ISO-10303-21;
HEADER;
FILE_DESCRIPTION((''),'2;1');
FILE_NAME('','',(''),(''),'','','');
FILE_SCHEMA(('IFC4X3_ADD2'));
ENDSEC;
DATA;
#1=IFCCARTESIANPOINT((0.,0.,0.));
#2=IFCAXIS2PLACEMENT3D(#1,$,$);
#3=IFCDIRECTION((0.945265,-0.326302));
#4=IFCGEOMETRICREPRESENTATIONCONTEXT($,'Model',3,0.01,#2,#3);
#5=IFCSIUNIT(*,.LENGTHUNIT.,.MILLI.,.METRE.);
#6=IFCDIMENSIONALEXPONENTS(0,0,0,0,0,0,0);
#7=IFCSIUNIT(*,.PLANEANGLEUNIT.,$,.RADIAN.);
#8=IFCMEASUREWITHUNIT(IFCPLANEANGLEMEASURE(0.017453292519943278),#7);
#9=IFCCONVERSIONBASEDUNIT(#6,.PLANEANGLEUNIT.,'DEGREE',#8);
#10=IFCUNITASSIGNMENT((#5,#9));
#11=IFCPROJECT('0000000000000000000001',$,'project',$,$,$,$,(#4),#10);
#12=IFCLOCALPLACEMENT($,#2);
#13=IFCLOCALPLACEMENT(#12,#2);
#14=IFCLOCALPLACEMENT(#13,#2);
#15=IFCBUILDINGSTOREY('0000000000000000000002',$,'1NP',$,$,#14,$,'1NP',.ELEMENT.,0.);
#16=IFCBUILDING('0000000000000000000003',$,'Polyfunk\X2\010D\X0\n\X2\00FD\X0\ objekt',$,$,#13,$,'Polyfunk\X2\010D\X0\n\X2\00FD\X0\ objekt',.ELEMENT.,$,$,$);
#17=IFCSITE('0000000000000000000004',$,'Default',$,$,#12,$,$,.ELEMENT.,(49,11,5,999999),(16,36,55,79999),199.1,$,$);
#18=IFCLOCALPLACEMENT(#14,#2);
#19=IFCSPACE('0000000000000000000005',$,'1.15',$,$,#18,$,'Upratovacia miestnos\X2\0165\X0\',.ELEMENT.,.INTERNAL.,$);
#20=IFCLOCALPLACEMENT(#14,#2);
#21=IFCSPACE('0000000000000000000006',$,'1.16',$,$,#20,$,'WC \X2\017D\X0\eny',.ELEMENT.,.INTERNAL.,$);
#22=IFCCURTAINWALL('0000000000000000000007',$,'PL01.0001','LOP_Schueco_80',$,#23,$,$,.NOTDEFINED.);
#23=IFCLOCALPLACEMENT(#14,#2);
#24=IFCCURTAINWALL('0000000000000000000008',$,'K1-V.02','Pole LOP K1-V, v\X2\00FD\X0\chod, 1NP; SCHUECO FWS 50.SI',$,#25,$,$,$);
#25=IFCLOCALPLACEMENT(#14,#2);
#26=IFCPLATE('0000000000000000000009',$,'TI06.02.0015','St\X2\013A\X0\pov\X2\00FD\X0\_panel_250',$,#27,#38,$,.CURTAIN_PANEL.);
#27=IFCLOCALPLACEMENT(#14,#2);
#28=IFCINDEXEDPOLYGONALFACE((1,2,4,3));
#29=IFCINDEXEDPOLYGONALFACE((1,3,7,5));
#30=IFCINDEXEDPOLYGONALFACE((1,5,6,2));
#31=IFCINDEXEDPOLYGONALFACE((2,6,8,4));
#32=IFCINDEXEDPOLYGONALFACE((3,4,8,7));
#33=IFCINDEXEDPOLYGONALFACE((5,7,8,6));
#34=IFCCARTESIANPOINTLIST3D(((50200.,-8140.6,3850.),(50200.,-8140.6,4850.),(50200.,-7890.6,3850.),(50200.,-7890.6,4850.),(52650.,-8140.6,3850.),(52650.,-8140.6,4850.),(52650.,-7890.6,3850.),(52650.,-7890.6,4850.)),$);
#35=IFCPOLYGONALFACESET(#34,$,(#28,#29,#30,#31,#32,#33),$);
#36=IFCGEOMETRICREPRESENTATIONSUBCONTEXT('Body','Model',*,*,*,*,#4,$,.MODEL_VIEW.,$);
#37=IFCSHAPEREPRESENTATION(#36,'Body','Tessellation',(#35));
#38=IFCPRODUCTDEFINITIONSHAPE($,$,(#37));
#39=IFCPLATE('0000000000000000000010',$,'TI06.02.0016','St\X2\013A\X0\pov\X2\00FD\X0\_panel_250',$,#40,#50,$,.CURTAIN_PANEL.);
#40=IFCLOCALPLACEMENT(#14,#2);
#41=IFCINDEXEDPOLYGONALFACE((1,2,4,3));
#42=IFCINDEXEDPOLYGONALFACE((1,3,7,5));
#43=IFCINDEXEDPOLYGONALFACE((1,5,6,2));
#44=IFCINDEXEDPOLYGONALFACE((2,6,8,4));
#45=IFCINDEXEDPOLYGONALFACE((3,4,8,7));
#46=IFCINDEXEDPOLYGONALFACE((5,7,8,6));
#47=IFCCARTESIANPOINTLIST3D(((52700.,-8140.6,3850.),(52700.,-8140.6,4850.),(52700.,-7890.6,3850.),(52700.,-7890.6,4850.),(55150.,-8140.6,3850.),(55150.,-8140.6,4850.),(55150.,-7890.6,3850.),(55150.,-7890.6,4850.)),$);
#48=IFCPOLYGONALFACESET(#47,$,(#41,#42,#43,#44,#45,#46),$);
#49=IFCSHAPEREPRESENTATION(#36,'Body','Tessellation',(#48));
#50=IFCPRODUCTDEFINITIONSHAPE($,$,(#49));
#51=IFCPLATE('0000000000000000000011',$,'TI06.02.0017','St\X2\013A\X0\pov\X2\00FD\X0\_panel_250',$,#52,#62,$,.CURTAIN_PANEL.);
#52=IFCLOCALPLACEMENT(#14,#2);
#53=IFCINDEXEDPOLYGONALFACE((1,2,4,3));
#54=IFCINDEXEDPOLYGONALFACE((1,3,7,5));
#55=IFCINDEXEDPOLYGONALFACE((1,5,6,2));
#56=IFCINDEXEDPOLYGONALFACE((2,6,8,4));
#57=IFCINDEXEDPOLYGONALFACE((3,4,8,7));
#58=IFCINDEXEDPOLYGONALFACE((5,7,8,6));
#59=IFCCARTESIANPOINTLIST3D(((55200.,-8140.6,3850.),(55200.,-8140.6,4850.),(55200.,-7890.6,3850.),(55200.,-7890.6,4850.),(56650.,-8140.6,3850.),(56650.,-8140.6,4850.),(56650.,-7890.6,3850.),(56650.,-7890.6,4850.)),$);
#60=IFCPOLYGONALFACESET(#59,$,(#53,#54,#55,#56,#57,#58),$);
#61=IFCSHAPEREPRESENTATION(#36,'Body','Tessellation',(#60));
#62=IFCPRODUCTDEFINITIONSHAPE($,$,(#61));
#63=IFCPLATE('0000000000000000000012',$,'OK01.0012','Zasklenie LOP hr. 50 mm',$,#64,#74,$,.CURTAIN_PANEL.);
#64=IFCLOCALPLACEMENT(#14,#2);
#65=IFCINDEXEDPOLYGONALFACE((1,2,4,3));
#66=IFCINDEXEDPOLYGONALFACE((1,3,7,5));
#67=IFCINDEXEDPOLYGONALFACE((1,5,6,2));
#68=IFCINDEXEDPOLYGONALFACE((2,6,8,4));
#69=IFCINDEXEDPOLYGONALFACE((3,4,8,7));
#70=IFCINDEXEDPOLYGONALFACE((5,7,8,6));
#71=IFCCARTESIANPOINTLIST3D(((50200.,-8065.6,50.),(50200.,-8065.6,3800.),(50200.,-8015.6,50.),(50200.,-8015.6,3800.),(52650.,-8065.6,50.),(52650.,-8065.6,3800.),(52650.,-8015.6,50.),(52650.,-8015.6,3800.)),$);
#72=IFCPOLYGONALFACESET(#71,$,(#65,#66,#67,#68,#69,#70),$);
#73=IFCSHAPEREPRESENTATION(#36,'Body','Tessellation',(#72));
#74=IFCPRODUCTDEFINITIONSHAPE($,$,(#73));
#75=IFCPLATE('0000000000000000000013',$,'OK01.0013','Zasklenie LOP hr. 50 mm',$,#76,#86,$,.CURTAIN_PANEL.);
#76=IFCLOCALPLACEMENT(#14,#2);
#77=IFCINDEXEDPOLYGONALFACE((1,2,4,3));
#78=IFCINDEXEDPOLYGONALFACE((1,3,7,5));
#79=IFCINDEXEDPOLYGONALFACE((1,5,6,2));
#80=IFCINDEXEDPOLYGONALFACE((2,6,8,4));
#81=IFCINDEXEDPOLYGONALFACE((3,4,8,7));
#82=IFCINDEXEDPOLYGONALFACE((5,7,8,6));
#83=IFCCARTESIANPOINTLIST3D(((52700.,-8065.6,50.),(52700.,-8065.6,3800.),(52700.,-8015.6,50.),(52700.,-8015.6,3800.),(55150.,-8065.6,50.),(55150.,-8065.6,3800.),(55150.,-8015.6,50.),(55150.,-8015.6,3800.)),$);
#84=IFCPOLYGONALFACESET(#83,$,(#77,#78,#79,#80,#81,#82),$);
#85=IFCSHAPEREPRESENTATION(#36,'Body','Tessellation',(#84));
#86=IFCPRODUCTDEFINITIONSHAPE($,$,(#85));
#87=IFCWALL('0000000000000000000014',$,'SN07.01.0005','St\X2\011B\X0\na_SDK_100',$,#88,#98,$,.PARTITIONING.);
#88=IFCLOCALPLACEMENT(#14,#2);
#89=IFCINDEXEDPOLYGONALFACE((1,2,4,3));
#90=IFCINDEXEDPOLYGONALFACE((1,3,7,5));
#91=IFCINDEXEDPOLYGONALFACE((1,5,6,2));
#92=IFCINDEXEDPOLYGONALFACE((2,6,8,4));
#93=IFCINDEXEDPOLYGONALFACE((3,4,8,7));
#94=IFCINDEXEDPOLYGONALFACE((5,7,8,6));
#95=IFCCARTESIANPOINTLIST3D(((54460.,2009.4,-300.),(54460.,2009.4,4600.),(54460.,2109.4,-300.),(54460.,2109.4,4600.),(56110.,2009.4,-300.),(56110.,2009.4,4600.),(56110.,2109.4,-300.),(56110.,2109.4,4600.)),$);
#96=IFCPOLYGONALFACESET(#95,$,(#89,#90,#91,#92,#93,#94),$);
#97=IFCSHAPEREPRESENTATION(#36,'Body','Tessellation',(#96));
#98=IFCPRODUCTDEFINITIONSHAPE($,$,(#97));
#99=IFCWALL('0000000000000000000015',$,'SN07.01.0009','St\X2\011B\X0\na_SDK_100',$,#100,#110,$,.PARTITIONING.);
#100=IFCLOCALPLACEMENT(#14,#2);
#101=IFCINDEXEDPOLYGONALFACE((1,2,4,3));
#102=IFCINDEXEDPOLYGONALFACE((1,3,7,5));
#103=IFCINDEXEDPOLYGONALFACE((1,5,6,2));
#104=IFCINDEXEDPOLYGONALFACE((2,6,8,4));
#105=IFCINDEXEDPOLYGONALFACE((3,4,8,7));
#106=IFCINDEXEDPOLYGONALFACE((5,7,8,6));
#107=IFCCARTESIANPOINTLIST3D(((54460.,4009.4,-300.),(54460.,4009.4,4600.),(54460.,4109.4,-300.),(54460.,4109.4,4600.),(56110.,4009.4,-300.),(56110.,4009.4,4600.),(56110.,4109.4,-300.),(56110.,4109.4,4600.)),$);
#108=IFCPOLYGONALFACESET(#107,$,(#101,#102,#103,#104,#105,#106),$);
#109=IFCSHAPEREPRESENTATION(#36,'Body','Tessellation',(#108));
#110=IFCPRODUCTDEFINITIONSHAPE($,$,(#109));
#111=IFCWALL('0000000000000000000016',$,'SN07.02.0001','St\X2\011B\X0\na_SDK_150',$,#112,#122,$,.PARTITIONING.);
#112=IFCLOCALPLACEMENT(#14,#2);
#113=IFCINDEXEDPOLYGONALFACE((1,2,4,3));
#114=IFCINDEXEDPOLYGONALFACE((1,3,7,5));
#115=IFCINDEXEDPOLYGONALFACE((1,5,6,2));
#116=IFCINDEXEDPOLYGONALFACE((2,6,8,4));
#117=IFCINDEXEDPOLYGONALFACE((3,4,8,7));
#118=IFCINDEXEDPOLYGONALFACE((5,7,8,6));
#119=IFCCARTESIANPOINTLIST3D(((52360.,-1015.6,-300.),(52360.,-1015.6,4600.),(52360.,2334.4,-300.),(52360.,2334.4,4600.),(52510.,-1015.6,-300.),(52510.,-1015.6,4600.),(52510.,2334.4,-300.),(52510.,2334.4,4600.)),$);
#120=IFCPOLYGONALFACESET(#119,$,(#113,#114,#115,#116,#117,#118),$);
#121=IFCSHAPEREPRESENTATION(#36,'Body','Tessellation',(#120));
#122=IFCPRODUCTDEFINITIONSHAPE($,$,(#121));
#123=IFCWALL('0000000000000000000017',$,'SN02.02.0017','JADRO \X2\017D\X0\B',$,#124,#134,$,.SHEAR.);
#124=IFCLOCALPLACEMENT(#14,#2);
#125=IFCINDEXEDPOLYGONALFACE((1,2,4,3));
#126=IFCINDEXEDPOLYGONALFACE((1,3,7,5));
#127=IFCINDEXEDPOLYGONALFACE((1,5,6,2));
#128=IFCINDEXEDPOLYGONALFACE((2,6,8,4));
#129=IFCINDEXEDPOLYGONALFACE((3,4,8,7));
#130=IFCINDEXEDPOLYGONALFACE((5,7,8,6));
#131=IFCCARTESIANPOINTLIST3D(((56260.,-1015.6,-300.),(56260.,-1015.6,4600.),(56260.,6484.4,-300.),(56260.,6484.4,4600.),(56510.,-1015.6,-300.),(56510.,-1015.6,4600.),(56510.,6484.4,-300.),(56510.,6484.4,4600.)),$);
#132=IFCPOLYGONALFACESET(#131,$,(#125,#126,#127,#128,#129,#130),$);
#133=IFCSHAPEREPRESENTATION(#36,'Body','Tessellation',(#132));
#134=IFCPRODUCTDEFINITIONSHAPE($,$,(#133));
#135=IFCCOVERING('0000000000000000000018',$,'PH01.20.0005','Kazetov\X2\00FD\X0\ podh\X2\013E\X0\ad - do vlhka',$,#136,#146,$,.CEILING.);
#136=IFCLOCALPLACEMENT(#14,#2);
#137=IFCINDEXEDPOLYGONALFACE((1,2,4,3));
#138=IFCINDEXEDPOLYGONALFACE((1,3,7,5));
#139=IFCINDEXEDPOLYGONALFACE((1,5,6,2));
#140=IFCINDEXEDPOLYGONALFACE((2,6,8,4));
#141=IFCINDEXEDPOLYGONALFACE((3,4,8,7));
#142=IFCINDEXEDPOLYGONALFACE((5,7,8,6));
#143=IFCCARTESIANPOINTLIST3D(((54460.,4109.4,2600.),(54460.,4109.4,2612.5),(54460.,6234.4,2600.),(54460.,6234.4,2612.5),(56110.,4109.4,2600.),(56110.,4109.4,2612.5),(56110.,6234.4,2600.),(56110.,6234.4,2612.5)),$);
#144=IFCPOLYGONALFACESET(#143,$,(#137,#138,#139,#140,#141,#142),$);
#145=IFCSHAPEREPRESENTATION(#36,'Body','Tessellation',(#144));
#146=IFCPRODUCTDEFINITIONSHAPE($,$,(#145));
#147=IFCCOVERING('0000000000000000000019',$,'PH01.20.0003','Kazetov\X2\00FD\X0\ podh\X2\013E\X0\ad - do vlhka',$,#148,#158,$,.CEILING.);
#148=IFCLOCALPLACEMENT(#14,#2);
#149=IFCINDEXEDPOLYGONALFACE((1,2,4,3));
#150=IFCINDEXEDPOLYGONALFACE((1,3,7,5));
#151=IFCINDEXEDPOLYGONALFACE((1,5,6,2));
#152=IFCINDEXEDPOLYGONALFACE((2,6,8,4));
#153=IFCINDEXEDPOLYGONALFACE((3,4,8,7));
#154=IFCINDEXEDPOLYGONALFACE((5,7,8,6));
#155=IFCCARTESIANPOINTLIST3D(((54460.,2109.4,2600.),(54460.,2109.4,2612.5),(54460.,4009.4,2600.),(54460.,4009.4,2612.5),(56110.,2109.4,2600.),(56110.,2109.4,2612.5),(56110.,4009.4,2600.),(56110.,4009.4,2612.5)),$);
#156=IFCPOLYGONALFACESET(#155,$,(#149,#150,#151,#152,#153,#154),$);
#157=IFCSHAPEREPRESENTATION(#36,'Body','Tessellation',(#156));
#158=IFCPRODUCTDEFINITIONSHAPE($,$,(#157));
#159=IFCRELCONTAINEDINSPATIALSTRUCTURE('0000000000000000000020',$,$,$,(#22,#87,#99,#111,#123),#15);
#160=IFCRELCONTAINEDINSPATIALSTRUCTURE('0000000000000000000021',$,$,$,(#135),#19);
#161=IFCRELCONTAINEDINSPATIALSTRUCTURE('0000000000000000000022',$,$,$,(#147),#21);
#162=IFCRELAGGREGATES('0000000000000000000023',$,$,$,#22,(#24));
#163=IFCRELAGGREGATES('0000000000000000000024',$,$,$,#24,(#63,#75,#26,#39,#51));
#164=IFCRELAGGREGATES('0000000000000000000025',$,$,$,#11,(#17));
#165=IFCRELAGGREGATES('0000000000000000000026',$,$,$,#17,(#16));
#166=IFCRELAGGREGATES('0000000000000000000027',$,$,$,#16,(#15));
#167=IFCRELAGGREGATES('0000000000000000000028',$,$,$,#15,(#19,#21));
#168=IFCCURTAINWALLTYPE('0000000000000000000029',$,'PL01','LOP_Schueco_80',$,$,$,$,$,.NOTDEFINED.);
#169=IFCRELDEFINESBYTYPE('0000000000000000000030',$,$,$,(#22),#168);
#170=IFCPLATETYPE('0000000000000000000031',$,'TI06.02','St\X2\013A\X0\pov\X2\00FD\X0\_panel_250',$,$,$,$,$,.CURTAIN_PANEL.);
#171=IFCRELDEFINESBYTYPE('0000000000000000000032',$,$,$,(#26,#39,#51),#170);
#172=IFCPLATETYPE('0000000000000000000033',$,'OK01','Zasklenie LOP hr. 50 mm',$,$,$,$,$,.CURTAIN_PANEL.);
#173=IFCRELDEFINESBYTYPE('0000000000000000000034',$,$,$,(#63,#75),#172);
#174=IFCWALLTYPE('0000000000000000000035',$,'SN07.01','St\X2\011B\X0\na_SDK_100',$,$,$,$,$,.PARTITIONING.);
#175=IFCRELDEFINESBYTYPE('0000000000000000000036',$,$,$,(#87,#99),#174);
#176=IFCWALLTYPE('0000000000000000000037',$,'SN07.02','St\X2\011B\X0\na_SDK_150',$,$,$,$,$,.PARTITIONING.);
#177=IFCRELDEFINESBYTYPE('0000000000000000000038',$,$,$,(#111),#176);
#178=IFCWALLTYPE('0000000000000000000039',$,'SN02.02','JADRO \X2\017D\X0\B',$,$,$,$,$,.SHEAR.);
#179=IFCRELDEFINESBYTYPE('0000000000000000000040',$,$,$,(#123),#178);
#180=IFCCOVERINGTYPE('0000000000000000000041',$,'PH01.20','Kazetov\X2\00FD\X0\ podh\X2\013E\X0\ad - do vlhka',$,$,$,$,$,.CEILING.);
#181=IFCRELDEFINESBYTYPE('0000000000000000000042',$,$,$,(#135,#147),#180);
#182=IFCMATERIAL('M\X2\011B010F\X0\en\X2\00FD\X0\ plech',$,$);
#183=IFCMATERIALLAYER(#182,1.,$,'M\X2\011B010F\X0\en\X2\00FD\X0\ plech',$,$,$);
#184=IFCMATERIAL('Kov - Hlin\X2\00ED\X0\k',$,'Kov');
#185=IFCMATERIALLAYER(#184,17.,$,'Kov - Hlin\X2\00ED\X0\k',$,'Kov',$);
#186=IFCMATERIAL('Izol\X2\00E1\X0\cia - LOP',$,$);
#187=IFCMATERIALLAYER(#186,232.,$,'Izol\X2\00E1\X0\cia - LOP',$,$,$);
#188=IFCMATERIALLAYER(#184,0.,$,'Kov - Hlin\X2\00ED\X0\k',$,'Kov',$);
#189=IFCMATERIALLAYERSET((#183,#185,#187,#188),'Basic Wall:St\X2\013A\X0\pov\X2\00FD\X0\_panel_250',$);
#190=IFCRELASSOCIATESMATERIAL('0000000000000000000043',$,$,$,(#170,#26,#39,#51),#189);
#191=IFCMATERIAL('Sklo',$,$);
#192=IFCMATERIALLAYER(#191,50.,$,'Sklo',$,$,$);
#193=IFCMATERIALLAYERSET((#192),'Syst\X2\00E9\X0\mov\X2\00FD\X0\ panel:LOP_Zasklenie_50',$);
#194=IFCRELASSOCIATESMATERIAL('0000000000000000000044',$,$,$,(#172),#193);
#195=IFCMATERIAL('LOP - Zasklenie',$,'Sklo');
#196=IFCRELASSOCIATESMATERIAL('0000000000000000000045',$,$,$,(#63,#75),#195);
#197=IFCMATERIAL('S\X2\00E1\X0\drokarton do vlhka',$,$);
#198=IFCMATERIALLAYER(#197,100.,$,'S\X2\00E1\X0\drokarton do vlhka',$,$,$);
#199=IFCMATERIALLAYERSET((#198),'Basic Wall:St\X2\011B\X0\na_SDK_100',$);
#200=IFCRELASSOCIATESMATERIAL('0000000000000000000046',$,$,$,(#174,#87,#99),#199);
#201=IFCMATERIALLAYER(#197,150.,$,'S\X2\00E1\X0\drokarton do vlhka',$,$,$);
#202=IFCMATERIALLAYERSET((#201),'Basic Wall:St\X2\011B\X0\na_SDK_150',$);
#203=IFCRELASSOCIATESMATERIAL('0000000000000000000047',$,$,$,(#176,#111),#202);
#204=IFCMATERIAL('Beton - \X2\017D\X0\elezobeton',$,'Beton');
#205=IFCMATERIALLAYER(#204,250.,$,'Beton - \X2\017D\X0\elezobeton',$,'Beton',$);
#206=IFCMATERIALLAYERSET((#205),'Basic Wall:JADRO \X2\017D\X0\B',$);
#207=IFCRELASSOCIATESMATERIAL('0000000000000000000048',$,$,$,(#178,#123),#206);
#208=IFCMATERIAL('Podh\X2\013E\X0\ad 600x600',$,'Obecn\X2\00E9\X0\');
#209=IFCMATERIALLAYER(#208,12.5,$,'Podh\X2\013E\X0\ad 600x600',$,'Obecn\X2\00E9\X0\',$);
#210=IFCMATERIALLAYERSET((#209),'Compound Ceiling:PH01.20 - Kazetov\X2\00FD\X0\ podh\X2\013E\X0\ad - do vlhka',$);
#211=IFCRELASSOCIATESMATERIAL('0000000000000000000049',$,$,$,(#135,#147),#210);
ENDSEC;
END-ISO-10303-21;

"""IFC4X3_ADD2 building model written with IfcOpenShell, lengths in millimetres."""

from ifc_helpers import new_model, entity, si_unit, converted_unit, direction, frame, frame_2d, origin, origin_2d_with_axis, place, context, subcontext, project, spatial, polyline, rectangle, extrude, clip, bounded_halfspace, source, transform, mapped, material, layer, layer_set, layer_usage, type_object, type_shapes, element, aggregate, save


model = new_model("IFC4X3_ADD2")

# Units and contexts
model_context = context("Model", 3, precision=0.01, world=origin(), true_north=direction((0.945265, -0.326302)))
body_context = subcontext(model_context, "Body", "Model", "MODEL_VIEW")
ifc_project = project(units=[si_unit("LENGTHUNIT", "METRE", prefix="MILLI"), converted_unit("PLANEANGLEUNIT", "DEGREE", entity("IfcPlaneAngleMeasure", 0.017453292519943278), si_unit("PLANEANGLEUNIT", "RADIAN"), dimensions=[0, 0, 0, 0, 0, 0, 0])], contexts=[model_context])

# Site, building, storey
site_placement = place(None, origin())
site = spatial("IfcSite", under=ifc_project, at=site_placement, Name="Default", CompositionType="ELEMENT", RefLatitude=(49, 11, 5, 999999), RefLongitude=(16, 36, 55, 79999), RefElevation=199.1)
building_placement = place(site_placement, origin())
building = spatial("IfcBuilding", under=site, at=building_placement, Name="Polyfunkčný objekt", LongName="Polyfunkčný objekt", CompositionType="ELEMENT")
storey_placement = place(building_placement, origin())
storey = spatial("IfcBuildingStorey", under=building, at=storey_placement, Name="1NP", LongName="1NP", CompositionType="ELEMENT", Elevation=0.0)

# Curtain walls, plates
curtain_wall_type = type_object("IfcCurtainWallType", Name="PL01", Description="LOP_Schueco_80", PredefinedType="NOTDEFINED")
curtain_wall_1_placement = place(storey_placement, origin())
curtain_wall_1 = element("IfcCurtainWall", 1, at=curtain_wall_1_placement, inside=storey, type_object=curtain_wall_type, Name="PL01.0001", Description="LOP_Schueco_80", PredefinedType="NOTDEFINED")
curtain_wall_2 = element("IfcCurtainWall", 2, Name="K1-V.02", Description="Pole LOP K1-V, východ, 1NP; SCHUECO FWS 50.SI")
aggregate(curtain_wall_1, [curtain_wall_2])
ifc_material_1 = material(Name="Měďený plech")
ifc_layer_1 = layer(ifc_material_1, 1.0, Name="Měďený plech")
ifc_material_2 = material(Name="Kov - Hliník", Category="Kov")
ifc_layer_2 = layer(ifc_material_2, 17.0, Name="Kov - Hliník", Category="Kov")
ifc_material_3 = material(Name="Izolácia - LOP")
ifc_layer_3 = layer(ifc_material_3, 232.0, Name="Izolácia - LOP")
ifc_layer_4 = layer(ifc_material_2, 0.0, Name="Kov - Hliník", Category="Kov")
ifc_layer_set_1 = layer_set([ifc_layer_1, ifc_layer_2, ifc_layer_3, ifc_layer_4], Name="Basic Wall:Stĺpový_panel_250")
ifc_layer_usage_1 = layer_usage(ifc_layer_set_1, "AXIS2", "POSITIVE", -125.0)
plate_type_1 = type_object("IfcPlateType", Name="TI06.02", Description="Stĺpový_panel_250", PredefinedType="CURTAIN_PANEL", material=ifc_layer_set_1)
plate_1_placement = place(storey_placement, frame((50200.0, -8015.6, 3850.0)))
plate_1 = element("IfcPlate", 3, at=plate_1_placement, type_object=plate_type_1, material=ifc_layer_usage_1, Name="TI06.02.0015", Description="Stĺpový_panel_250", PredefinedType="CURTAIN_PANEL", context=body_context, shape_type="SweptSolid", body=[
    extrude(rectangle(XDim=250.0, YDim=2450.0, at=origin_2d_with_axis()), frame((1225.0, 0.0, 0.0), z_axis=(0.0, 0.0, 1.0), x_axis=(0.0, 1.0, 0.0)), (0.0, 0.0, 1.0), 1000.0),
])
ifc_layer_usage_2 = layer_usage(ifc_layer_set_1, "AXIS2", "POSITIVE", -125.0)
plate_2_placement = place(storey_placement, frame((52700.0, -8015.6, 3850.0)))
plate_2 = element("IfcPlate", 4, at=plate_2_placement, type_object=plate_type_1, material=ifc_layer_usage_2, Name="TI06.02.0016", Description="Stĺpový_panel_250", PredefinedType="CURTAIN_PANEL", context=body_context, shape_type="SweptSolid", body=[
    extrude(rectangle(XDim=250.0, YDim=2450.0, at=frame_2d((0.0, 0.0), x_axis=(1.0, 0.0))), frame((1225.0, 0.0, 0.0), z_axis=(0.0, 0.0, 1.0), x_axis=(0.0, 1.0, 0.0)), (0.0, 0.0, 1.0), 1000.0),
])
ifc_layer_usage_3 = layer_usage(ifc_layer_set_1, "AXIS2", "POSITIVE", -125.0)
plate_3_placement = place(storey_placement, frame((55200.0, -8015.6, 3850.0)))
plate_3 = element("IfcPlate", 5, at=plate_3_placement, type_object=plate_type_1, material=ifc_layer_usage_3, Name="TI06.02.0017", Description="Stĺpový_panel_250", PredefinedType="CURTAIN_PANEL", context=body_context, shape_type="SweptSolid", body=[
    extrude(rectangle(XDim=250.0, YDim=1450.0, at=frame_2d((0.0, 0.0), x_axis=(1.0, 0.0))), frame((725.0, 0.0, 0.0), z_axis=(0.0, 0.0, 1.0), x_axis=(0.0, 1.0, 0.0)), (0.0, 0.0, 1.0), 1000.0),
])
ifc_material_4 = material(Name="LOP - Zasklenie", Category="Sklo")
ifc_material_5 = material(Name="Sklo")
ifc_layer_5 = layer(ifc_material_5, 50.0, Name="Sklo")
ifc_layer_set_2 = layer_set([ifc_layer_5], Name="Systémový panel:LOP_Zasklenie_50")
plate_type_2 = type_object("IfcPlateType", Name="OK01", Description="Zasklenie LOP hr. 50 mm", PredefinedType="CURTAIN_PANEL", material=ifc_layer_set_2)
shared_shape_1 = source(origin(), body_context, "Body", "SweptSolid", [
    extrude(rectangle(XDim=3750.0, YDim=2450.0, at=frame_2d((-331.2, 0.0), x_axis=(1.0, 0.0))), frame((0.0, -50.0, 2206.2), z_axis=(0.0, 1.0, 0.0), x_axis=(0.0, 0.0, 1.0)), (0.0, 0.0, 1.0), 50.0),
])
type_shapes(plate_type_2, [shared_shape_1])
plate_4_placement = place(curtain_wall_1_placement, frame((51425.0, -8015.6, 50.0)))
plate_4 = element("IfcPlate", 6, at=plate_4_placement, type_object=plate_type_2, material=ifc_material_4, Name="OK01.0012", Description="Zasklenie LOP hr. 50 mm", PredefinedType="CURTAIN_PANEL", context=body_context, shape_type="MappedRepresentation", body=[
    mapped(shared_shape_1, transform((0.0, 0.0, 0.0), scale=1.0)),
])
plate_5_placement = place(curtain_wall_1_placement, frame((53925.0, -8015.6, 50.0)))
plate_5 = element("IfcPlate", 7, at=plate_5_placement, type_object=plate_type_2, material=ifc_material_4, Name="OK01.0013", Description="Zasklenie LOP hr. 50 mm", PredefinedType="CURTAIN_PANEL", context=body_context, shape_type="MappedRepresentation", body=[
    mapped(shared_shape_1, transform((0.0, 0.0, 0.0), scale=1.0)),
])
aggregate(curtain_wall_2, [plate_4, plate_5, plate_1, plate_2, plate_3])

# Walls
ifc_material_6 = material(Name="Sádrokarton do vlhka")
ifc_layer_6 = layer(ifc_material_6, 100.0, Name="Sádrokarton do vlhka")
ifc_layer_set_3 = layer_set([ifc_layer_6], Name="Basic Wall:Stěna_SDK_100")
wall_type_1 = type_object("IfcWallType", Name="SN07.01", Description="Stěna_SDK_100", PredefinedType="PARTITIONING", material=ifc_layer_set_3)
wall_1_placement = place(storey_placement, frame((54460.0, 2059.4, -300.0)))
element("IfcWall", 8, at=wall_1_placement, inside=storey, type_object=wall_type_1, material=ifc_layer_set_3, Name="SN07.01.0005", Description="Stěna_SDK_100", PredefinedType="PARTITIONING", context=body_context, shape_type="Clipping", body=[
    clip(clip(extrude(rectangle(XDim=1650.0, YDim=100.0, at=frame_2d((825.0, 0.0), x_axis=(-1.0, 0.0))), origin(), (0.0, 0.0, 1.0), 4900.0), bounded_halfspace(frame((0.0, -50.0, 4900.0), z_axis=(0.0, 0.0, -1.0), x_axis=(1.0, 0.0, 0.0)), True, frame((0.0, -50.0, 4900.0)), polyline([(0.0, 0.0), (1650.0, 0.0), (1650.0, 100.0), (0.0, 100.0), (0.0, 0.0)]))), bounded_halfspace(frame((1650.0, -50.0, 0.0), z_axis=(0.0, 0.0, 1.0), x_axis=(0.0, 1.0, 0.0)), True, frame((1650.0, -50.0, 0.0)), polyline([(0.0, 0.0), (0.0, 100.0), (-1650.0, 100.0), (-1650.0, 0.0), (0.0, 0.0)]))),
])
wall_2_placement = place(storey_placement, frame((54460.0, 4059.4, -300.0)))
element("IfcWall", 9, at=wall_2_placement, inside=storey, type_object=wall_type_1, material=ifc_layer_set_3, Name="SN07.01.0009", Description="Stěna_SDK_100", PredefinedType="PARTITIONING", context=body_context, shape_type="Clipping", body=[
    clip(clip(extrude(rectangle(XDim=1650.0, YDim=100.0, at=frame_2d((825.0, 0.0), x_axis=(-1.0, 0.0))), origin(), (0.0, 0.0, 1.0), 4900.0), bounded_halfspace(frame((0.0, -50.0, 4900.0), z_axis=(0.0, 0.0, -1.0), x_axis=(1.0, 0.0, 0.0)), True, frame((0.0, -50.0, 4900.0)), polyline([(0.0, 0.0), (1650.0, 0.0), (1650.0, 100.0), (0.0, 100.0), (0.0, 0.0)]))), bounded_halfspace(frame((1650.0, -50.0, 0.0), z_axis=(0.0, 0.0, 1.0), x_axis=(0.0, 1.0, 0.0)), True, frame((1650.0, -50.0, 0.0)), polyline([(0.0, 0.0), (0.0, 100.0), (-1650.0, 100.0), (-1650.0, 0.0), (0.0, 0.0)]))),
])
ifc_layer_7 = layer(ifc_material_6, 150.0, Name="Sádrokarton do vlhka")
ifc_layer_set_4 = layer_set([ifc_layer_7], Name="Basic Wall:Stěna_SDK_150")
wall_type_2 = type_object("IfcWallType", Name="SN07.02", Description="Stěna_SDK_150", PredefinedType="PARTITIONING", material=ifc_layer_set_4)
wall_3_placement = place(storey_placement, frame((52435.0, 2334.4, -300.0), z_axis=(0.0, 0.0, 1.0), x_axis=(0.0, -1.0, 0.0)))
element("IfcWall", 10, at=wall_3_placement, inside=storey, type_object=wall_type_2, material=ifc_layer_set_4, Name="SN07.02.0001", Description="Stěna_SDK_150", PredefinedType="PARTITIONING", context=body_context, shape_type="Clipping", body=[
    clip(clip(extrude(rectangle(XDim=3350.0, YDim=150.0, at=frame_2d((1675.0, 0.0), x_axis=(-1.0, 0.0))), origin(), (0.0, 0.0, 1.0), 4900.0), bounded_halfspace(frame((3350.0, -75.0, 0.0), z_axis=(0.0, 0.0, 1.0), x_axis=(-1.0, 0.0, 0.0)), True, frame((3350.0, -75.0, 0.0)), polyline([(0.0, 0.0), (0.0, 150.0), (-3350.0, 150.0), (-3350.0, 0.0), (0.0, 0.0)]))), bounded_halfspace(frame((0.0, -75.0, 4900.0), z_axis=(0.0, 0.0, -1.0), x_axis=(0.0, 1.0, 0.0)), True, frame((0.0, -75.0, 4900.0)), polyline([(0.0, 0.0), (3350.0, 0.0), (3350.0, 150.0), (0.0, 150.0), (0.0, 0.0)]))),
])
ifc_material_7 = material(Name="Beton - Železobeton", Category="Beton")
ifc_layer_8 = layer(ifc_material_7, 250.0, Name="Beton - Železobeton", Category="Beton")
ifc_layer_set_5 = layer_set([ifc_layer_8], Name="Basic Wall:JADRO ŽB")
wall_type_3 = type_object("IfcWallType", Name="SN02.02", Description="JADRO ŽB", PredefinedType="SHEAR", material=ifc_layer_set_5)
wall_4_placement = place(storey_placement, frame((56385.0, -1015.6, -300.0), z_axis=(0.0, 0.0, 1.0), x_axis=(0.0, 1.0, 0.0)))
element("IfcWall", 11, at=wall_4_placement, inside=storey, type_object=wall_type_3, material=ifc_layer_set_5, Name="SN02.02.0017", Description="JADRO ŽB", PredefinedType="SHEAR", context=body_context, shape_type="Clipping", body=[
    clip(clip(extrude(rectangle(XDim=7500.0, YDim=250.0, at=frame_2d((3750.0, 0.0), x_axis=(-1.0, 0.0))), origin(), (0.0, 0.0, 1.0), 4900.0), bounded_halfspace(frame((0.0, -125.0, 4900.0), z_axis=(0.0, 0.0, -1.0), x_axis=(0.0, -1.0, 0.0)), True, frame((0.0, -125.0, 4900.0)), polyline([(0.0, 0.0), (7500.0, 0.0), (7500.0, 250.0), (7250.0, 250.0), (0.0, 250.0), (0.0, 0.0)]))), bounded_halfspace(frame((0.0, -125.0, 0.0)), True, frame((0.0, -125.0, 0.0)), polyline([(0.0, 0.0), (7110.0, 0.0), (7500.0, 0.0), (7500.0, 250.0), (7250.0, 250.0), (0.0, 250.0), (0.0, 0.0)]))),
])

# Shared definitions
ifc_material_8 = material(Name="Podhľad 600x600", Category="Obecné")

# Shared definitions
space_1_placement = place(storey_placement, origin())
space_1 = spatial("IfcSpace", under=storey, at=space_1_placement, Name="1.15", LongName="Upratovacia miestnosť", CompositionType="ELEMENT", PredefinedType="INTERNAL")

# Covering
ifc_layer_9 = layer(ifc_material_8, 12.5, Name="Podhľad 600x600", Category="Obecné")
ifc_layer_set_6 = layer_set([ifc_layer_9], Name="Compound Ceiling:PH01.20 - Kazetový podhľad - do vlhka")
ifc_layer_usage_4 = layer_usage(ifc_layer_set_6, "AXIS3", "NEGATIVE", 0.0)
covering_type_1 = type_object("IfcCoveringType", Name="PH01.20", Description="Kazetový podhľad - do vlhka", PredefinedType="CEILING")
covering_1_placement = place(storey_placement, frame((54460.0, 4109.4, 2600.0)))
element("IfcCovering", 12, at=covering_1_placement, inside=space_1, type_object=covering_type_1, material=ifc_layer_usage_4, Name="PH01.20.0005", Description="Kazetový podhľad - do vlhka", PredefinedType="CEILING", context=body_context, shape_type="SweptSolid", body=[
    extrude(rectangle(XDim=2125.0, YDim=1650.0, at=frame_2d((0.0, 0.0), x_axis=(1.0, 0.0))), frame((825.0, 1062.5, 0.0), z_axis=(0.0, 0.0, 1.0), x_axis=(0.0, -1.0, 0.0)), (0.0, 0.0, 1.0), 12.5),
])

# Shared definitions
space_2_placement = place(storey_placement, origin())
space_2 = spatial("IfcSpace", under=storey, at=space_2_placement, Name="1.16", LongName="WC Ženy", CompositionType="ELEMENT", PredefinedType="INTERNAL")

# Covering
ifc_layer_usage_5 = layer_usage(ifc_layer_set_6, "AXIS3", "NEGATIVE", 0.0)
covering_2_placement = place(storey_placement, frame((54460.0, 2109.4, 2600.0)))
element("IfcCovering", 13, at=covering_2_placement, inside=space_2, type_object=covering_type_1, material=ifc_layer_usage_5, Name="PH01.20.0003", Description="Kazetový podhľad - do vlhka", PredefinedType="CEILING", context=body_context, shape_type="SweptSolid", body=[
    extrude(rectangle(XDim=1900.0, YDim=1650.0, at=frame_2d((0.0, 0.0), x_axis=(1.0, 0.0))), frame((825.0, 950.0, 0.0), z_axis=(0.0, 0.0, 1.0), x_axis=(0.0, 1.0, 0.0)), (0.0, 0.0, 1.0), 12.5),
])

save(model, "model.ifc")
